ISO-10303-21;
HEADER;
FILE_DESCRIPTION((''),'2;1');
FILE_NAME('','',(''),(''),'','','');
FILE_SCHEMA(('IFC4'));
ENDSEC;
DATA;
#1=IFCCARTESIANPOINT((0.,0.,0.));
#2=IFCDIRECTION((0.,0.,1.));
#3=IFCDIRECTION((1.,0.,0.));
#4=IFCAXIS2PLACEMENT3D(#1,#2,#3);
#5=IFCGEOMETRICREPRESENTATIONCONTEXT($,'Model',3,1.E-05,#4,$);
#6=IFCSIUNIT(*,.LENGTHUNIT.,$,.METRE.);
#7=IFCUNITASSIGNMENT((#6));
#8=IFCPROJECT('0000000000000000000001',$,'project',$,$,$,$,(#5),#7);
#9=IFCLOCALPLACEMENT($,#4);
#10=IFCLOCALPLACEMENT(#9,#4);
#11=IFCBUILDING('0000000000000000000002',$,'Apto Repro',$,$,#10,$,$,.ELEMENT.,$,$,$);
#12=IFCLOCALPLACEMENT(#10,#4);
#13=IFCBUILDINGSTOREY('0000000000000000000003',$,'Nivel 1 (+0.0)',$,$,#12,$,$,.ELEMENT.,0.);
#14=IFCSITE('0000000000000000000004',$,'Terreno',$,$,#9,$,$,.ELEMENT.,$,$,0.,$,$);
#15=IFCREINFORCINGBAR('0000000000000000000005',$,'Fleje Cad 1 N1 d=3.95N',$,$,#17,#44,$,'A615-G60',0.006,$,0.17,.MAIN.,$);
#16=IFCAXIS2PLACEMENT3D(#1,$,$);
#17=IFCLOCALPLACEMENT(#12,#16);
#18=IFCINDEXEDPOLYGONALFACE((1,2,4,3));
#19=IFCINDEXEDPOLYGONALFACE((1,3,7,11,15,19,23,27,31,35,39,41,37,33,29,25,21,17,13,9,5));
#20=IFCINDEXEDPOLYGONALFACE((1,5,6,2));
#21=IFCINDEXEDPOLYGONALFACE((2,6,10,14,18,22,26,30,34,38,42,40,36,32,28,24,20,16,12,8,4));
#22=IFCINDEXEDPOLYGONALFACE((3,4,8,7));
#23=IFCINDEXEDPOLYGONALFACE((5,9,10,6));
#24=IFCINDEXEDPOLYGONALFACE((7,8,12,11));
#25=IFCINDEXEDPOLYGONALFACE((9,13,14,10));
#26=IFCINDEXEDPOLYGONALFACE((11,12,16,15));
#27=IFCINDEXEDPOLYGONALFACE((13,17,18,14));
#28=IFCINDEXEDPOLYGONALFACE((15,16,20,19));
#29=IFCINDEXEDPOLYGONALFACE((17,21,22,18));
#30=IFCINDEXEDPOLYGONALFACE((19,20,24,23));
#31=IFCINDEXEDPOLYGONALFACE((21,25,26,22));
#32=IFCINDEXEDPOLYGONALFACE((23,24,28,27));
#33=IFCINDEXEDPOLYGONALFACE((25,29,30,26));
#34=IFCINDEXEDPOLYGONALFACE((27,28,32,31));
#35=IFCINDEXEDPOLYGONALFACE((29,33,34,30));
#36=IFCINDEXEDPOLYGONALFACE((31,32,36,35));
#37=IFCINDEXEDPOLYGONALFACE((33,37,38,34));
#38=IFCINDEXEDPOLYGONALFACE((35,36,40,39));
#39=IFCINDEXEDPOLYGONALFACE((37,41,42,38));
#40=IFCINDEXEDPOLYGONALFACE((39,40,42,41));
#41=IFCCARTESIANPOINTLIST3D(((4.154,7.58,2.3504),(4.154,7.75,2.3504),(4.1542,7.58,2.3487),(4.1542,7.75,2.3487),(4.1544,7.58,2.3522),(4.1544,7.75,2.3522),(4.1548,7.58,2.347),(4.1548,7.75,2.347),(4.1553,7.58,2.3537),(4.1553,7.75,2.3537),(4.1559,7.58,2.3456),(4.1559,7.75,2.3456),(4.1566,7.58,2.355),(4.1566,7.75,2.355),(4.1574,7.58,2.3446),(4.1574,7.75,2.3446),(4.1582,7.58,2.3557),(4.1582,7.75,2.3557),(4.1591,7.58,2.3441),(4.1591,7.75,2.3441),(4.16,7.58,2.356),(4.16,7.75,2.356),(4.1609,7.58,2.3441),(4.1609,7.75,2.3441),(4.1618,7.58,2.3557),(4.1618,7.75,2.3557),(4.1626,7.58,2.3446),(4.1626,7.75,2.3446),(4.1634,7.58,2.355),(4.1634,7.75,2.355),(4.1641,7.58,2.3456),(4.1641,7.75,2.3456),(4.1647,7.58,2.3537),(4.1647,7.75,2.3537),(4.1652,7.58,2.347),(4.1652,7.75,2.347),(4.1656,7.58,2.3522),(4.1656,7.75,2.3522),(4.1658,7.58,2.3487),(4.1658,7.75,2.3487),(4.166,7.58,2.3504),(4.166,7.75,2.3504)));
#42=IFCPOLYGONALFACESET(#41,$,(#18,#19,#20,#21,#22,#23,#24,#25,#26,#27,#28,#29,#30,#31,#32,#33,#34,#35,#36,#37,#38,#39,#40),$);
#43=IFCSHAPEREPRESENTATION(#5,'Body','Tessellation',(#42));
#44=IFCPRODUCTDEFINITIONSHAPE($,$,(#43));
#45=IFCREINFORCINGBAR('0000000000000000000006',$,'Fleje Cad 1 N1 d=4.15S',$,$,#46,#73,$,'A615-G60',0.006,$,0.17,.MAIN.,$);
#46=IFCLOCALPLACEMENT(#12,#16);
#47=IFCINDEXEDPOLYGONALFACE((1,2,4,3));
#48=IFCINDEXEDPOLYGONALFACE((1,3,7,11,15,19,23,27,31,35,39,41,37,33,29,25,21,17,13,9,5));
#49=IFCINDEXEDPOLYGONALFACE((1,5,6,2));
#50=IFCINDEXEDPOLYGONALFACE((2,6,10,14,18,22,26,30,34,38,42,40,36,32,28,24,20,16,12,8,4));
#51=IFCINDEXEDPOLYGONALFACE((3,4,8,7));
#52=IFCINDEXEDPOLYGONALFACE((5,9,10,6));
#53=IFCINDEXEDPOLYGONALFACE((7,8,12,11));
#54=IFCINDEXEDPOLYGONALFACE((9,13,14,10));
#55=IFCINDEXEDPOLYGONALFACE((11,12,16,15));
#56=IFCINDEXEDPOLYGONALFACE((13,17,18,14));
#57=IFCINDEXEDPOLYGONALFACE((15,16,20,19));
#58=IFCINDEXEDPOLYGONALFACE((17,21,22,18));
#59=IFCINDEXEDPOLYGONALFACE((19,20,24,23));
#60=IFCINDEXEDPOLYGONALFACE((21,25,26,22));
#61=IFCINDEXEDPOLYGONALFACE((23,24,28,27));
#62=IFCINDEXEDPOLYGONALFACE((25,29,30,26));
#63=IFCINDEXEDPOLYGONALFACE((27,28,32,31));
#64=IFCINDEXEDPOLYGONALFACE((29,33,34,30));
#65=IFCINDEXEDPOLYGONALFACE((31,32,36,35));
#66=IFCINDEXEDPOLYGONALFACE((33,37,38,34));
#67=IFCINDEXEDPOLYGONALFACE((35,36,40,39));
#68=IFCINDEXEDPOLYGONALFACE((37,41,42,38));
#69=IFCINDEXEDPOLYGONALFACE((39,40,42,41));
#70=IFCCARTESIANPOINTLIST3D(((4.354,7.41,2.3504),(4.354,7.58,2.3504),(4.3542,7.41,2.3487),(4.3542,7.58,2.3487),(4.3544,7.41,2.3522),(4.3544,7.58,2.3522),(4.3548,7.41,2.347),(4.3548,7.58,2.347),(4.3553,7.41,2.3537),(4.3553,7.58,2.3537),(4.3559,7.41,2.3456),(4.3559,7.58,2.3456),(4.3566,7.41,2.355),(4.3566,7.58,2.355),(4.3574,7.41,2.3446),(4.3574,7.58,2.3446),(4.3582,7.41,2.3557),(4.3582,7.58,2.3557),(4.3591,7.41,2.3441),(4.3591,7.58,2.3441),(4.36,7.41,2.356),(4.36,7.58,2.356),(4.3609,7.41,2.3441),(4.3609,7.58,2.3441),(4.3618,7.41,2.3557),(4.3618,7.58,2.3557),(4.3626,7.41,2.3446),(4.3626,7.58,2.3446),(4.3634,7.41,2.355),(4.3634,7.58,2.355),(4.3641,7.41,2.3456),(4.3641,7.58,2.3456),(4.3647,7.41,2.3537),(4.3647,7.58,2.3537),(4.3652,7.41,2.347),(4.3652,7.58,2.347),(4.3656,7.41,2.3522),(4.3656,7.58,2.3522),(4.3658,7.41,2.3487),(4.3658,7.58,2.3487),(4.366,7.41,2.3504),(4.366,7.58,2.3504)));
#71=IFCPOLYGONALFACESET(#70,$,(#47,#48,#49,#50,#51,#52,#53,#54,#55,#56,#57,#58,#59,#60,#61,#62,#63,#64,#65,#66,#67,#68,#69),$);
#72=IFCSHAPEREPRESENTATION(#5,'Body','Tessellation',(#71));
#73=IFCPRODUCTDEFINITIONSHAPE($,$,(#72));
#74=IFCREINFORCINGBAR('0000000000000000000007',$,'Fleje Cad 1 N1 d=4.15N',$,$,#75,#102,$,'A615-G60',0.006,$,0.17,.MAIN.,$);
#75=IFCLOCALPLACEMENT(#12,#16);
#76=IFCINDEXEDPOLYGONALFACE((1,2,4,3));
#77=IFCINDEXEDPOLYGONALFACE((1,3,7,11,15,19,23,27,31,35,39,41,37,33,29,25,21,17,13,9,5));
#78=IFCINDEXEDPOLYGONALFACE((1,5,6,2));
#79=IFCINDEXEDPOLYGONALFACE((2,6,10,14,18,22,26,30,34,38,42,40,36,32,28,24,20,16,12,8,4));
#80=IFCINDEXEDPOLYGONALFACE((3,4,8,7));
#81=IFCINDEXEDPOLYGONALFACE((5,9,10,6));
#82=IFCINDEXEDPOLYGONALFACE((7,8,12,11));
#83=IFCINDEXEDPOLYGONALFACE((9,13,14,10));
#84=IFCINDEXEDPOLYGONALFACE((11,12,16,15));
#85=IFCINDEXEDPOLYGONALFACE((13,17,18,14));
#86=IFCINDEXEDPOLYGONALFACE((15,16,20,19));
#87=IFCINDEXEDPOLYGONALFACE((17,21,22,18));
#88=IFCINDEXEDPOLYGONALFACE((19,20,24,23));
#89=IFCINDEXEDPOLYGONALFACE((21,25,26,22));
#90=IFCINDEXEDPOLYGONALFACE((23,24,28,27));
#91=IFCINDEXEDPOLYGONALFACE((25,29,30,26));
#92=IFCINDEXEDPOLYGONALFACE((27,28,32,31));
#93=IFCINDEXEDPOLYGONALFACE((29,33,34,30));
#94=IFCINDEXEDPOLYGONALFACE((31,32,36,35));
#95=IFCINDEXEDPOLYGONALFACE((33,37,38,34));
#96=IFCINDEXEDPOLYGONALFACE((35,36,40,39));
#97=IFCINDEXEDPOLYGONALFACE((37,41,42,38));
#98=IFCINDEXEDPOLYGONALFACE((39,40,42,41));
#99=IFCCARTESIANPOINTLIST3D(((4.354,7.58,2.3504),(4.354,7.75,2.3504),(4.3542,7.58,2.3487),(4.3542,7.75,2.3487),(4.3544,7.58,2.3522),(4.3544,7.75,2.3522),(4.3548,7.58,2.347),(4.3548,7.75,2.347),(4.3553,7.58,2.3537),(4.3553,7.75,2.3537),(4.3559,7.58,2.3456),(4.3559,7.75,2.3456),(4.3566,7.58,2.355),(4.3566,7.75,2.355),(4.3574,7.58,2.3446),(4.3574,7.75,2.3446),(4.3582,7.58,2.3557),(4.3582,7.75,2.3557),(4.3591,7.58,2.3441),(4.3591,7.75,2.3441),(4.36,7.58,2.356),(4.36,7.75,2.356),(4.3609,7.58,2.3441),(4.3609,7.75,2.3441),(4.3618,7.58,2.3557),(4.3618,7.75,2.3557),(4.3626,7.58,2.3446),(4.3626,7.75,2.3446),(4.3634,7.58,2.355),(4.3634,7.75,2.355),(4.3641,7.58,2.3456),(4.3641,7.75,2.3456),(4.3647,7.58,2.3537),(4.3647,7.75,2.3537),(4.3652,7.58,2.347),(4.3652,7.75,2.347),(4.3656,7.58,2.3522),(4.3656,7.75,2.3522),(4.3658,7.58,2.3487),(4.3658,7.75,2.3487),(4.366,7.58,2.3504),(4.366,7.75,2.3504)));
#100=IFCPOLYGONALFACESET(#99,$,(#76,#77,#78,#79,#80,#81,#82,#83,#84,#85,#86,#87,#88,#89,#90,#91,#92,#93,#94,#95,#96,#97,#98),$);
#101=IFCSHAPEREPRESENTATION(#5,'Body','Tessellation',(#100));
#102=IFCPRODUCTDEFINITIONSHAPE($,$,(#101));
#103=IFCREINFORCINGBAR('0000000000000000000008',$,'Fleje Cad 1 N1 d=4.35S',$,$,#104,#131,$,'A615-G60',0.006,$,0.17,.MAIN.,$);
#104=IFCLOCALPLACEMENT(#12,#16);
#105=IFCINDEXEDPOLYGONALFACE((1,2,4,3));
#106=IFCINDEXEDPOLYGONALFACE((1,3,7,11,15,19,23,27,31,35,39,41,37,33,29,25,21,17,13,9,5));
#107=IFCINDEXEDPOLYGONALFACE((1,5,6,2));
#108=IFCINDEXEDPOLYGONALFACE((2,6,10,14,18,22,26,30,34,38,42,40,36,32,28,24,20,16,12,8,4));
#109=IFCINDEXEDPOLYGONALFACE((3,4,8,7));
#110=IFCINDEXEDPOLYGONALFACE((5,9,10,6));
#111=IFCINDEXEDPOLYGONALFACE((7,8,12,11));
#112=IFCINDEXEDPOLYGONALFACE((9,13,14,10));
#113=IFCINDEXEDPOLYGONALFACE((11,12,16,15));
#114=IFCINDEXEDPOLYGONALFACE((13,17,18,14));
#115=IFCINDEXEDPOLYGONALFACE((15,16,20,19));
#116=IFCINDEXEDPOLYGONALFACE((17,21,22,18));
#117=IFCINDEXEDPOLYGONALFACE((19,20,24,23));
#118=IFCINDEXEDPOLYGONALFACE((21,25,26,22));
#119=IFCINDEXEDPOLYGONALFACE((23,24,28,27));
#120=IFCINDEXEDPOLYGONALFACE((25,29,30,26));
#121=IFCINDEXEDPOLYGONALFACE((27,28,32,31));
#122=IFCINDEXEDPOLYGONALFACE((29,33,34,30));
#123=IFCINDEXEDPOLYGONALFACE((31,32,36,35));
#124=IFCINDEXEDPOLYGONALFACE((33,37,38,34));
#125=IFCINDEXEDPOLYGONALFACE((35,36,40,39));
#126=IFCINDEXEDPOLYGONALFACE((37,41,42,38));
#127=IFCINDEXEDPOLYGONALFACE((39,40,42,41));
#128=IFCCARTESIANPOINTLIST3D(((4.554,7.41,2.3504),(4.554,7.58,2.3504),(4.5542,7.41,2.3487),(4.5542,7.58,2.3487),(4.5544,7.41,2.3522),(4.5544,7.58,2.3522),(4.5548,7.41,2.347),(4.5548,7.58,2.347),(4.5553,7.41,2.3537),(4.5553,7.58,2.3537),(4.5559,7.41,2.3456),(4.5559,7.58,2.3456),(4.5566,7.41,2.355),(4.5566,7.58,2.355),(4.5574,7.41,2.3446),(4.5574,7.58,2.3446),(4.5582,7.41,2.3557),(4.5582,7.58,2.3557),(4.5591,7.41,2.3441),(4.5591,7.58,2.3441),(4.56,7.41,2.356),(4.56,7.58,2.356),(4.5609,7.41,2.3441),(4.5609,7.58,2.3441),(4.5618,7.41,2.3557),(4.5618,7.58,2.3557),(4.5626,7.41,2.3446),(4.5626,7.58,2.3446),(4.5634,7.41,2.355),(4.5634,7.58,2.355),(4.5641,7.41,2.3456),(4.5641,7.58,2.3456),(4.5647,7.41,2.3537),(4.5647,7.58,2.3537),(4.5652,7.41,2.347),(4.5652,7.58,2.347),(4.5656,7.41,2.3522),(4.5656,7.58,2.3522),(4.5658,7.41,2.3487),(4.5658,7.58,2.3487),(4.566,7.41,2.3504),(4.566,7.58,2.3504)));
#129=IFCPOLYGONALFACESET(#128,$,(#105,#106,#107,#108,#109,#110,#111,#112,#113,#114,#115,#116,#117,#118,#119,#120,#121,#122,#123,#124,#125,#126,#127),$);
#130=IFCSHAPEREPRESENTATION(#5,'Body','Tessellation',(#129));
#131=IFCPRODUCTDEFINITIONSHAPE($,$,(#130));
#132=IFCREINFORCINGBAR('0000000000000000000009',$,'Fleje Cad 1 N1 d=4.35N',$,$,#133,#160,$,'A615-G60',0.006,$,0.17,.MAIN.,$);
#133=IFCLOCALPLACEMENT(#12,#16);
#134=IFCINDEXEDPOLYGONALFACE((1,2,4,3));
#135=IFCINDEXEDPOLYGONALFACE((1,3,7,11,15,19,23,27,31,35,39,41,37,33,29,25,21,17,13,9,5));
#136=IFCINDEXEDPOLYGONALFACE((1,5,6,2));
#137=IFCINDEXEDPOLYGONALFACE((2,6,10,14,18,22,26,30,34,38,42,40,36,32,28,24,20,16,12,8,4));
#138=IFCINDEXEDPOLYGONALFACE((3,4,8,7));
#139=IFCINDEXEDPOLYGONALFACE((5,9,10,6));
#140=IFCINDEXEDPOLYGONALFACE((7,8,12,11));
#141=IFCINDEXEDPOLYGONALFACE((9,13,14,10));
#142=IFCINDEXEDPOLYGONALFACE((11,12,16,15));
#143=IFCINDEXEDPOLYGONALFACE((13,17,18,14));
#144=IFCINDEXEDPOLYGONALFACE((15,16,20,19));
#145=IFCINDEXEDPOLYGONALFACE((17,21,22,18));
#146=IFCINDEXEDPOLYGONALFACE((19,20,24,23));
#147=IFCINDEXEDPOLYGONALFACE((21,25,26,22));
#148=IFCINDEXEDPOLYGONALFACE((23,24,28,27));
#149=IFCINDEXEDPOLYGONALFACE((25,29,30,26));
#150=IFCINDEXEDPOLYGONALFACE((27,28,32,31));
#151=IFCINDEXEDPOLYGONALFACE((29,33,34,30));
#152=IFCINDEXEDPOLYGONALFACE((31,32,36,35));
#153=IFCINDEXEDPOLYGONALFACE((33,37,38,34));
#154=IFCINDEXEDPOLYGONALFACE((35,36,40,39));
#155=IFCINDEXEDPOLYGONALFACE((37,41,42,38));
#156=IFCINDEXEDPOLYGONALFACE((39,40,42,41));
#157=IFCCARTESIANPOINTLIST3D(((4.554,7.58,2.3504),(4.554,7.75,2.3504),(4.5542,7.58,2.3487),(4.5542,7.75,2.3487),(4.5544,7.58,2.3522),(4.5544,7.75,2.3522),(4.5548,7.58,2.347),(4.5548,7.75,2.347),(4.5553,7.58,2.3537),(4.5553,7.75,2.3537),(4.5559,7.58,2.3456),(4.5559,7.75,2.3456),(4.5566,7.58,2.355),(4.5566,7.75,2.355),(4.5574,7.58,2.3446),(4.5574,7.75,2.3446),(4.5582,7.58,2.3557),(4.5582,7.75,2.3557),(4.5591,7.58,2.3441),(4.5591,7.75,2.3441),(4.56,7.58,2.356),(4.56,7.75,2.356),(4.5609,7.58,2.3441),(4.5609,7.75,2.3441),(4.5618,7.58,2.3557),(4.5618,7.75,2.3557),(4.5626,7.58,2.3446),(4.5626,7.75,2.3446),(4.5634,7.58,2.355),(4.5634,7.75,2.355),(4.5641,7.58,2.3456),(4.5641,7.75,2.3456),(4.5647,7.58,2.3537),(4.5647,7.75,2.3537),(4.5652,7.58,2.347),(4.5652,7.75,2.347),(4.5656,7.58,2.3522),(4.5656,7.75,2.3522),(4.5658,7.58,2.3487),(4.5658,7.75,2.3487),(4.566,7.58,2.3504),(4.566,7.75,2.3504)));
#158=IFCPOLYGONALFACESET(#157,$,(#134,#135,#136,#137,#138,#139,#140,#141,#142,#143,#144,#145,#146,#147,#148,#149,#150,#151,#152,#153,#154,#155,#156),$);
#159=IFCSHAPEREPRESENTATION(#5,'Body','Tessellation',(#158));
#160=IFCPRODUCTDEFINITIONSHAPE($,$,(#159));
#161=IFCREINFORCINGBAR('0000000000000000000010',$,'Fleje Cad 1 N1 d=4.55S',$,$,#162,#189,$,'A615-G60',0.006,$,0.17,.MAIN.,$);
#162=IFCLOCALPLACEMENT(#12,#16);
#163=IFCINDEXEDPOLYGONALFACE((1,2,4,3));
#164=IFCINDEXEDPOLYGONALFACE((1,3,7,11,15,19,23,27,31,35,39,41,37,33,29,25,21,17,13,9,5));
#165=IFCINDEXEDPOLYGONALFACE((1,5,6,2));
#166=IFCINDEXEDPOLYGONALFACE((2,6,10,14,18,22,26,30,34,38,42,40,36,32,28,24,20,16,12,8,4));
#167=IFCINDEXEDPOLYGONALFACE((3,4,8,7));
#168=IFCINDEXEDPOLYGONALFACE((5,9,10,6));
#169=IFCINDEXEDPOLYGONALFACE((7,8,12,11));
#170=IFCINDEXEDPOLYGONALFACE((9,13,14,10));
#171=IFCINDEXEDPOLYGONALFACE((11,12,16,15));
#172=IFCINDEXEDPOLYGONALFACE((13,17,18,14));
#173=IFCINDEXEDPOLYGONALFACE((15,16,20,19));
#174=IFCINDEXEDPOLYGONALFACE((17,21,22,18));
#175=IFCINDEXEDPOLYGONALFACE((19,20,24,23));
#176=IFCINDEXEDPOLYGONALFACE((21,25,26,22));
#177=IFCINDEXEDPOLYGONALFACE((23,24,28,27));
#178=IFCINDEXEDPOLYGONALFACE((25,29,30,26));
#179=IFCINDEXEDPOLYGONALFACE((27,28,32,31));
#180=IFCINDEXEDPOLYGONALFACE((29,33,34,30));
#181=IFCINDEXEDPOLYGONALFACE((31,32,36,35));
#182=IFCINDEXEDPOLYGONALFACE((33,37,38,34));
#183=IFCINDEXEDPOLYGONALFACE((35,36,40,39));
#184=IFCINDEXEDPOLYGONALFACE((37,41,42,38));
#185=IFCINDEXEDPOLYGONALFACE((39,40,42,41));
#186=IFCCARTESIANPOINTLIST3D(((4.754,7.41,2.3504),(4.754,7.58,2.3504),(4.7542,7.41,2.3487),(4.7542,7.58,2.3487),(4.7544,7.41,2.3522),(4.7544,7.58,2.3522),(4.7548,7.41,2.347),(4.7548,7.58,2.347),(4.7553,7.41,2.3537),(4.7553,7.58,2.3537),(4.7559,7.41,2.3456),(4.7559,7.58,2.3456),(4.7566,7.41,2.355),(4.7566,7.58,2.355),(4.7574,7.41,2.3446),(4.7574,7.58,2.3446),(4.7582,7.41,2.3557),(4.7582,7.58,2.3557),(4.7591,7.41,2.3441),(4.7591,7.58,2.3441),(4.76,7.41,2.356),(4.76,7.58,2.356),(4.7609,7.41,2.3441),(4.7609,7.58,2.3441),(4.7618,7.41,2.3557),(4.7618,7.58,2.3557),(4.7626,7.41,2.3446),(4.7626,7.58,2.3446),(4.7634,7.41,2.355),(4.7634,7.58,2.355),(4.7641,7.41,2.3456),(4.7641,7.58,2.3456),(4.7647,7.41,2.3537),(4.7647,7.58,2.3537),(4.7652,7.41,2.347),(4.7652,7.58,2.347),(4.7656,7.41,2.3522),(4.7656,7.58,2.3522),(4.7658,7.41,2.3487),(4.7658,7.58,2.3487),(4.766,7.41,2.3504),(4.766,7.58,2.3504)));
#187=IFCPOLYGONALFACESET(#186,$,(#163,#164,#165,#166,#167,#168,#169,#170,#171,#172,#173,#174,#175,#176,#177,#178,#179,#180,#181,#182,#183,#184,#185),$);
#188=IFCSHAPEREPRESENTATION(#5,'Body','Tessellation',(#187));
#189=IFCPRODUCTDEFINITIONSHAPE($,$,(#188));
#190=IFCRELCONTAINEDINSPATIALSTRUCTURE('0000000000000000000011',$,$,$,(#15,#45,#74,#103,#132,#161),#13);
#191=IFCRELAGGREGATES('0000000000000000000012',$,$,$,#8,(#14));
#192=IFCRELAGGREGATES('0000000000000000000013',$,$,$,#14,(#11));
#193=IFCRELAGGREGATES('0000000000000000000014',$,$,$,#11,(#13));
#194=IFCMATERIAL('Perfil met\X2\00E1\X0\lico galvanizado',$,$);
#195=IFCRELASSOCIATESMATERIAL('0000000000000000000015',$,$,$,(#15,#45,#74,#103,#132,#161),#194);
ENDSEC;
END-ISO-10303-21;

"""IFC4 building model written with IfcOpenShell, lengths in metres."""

from ifc_helpers import new_model, si_unit, frame, origin_with_axes, origin_2d_with_axis, place, context, project, spatial, circle, extrude, material, element, save


model = new_model("IFC4")

# Units and contexts
model_context = context("Model", 3, precision=1e-05, world=origin_with_axes())
ifc_project = project(units=[si_unit("LENGTHUNIT", "METRE")], contexts=[model_context])

# Site, building, storey
site_placement = place(None, origin_with_axes())
site = spatial("IfcSite", under=ifc_project, at=site_placement, Name="Terreno", CompositionType="ELEMENT", RefElevation=0.0)
building_placement = place(site_placement, origin_with_axes())
building = spatial("IfcBuilding", under=site, at=building_placement, Name="Apto Repro", CompositionType="ELEMENT")
storey_placement = place(building_placement, origin_with_axes())
storey = spatial("IfcBuildingStorey", under=building, at=storey_placement, Name="Nivel 1 (+0.0)", CompositionType="ELEMENT", Elevation=0.0)

# Reinforcing bars
ifc_material = material(Name="Perfil metálico galvanizado")
reinforcing_bar_1_placement = place(storey_placement, origin_with_axes())
element("IfcReinforcingBar", 1, at=reinforcing_bar_1_placement, inside=storey, material=ifc_material, Name="Fleje Cad 1 N1 d=3.95N", SteelGrade="A615-G60", BarLength=0.17, NominalDiameter=0.006, PredefinedType="MAIN", context=model_context, shape_type="SweptSolid", body=[
    extrude(circle(Radius=0.006, at=origin_2d_with_axis()), frame((4.16, 7.58, 2.35), z_axis=(0.0, 1.0, 0.0), x_axis=(0.0, 0.0, 1.0)), (0.0, 0.0, 1.0), 0.17),
])
reinforcing_bar_2_placement = place(storey_placement, origin_with_axes())
element("IfcReinforcingBar", 2, at=reinforcing_bar_2_placement, inside=storey, material=ifc_material, Name="Fleje Cad 1 N1 d=4.15S", SteelGrade="A615-G60", BarLength=0.17, NominalDiameter=0.006, PredefinedType="MAIN", context=model_context, shape_type="SweptSolid", body=[
    extrude(circle(Radius=0.006, at=origin_2d_with_axis()), frame((4.36, 7.41, 2.35), z_axis=(0.0, 1.0, 0.0), x_axis=(0.0, 0.0, 1.0)), (0.0, 0.0, 1.0), 0.17),
])
reinforcing_bar_3_placement = place(storey_placement, origin_with_axes())
element("IfcReinforcingBar", 3, at=reinforcing_bar_3_placement, inside=storey, material=ifc_material, Name="Fleje Cad 1 N1 d=4.15N", SteelGrade="A615-G60", BarLength=0.17, NominalDiameter=0.006, PredefinedType="MAIN", context=model_context, shape_type="SweptSolid", body=[
    extrude(circle(Radius=0.006, at=origin_2d_with_axis()), frame((4.36, 7.58, 2.35), z_axis=(0.0, 1.0, 0.0), x_axis=(0.0, 0.0, 1.0)), (0.0, 0.0, 1.0), 0.17),
])
reinforcing_bar_4_placement = place(storey_placement, origin_with_axes())
element("IfcReinforcingBar", 4, at=reinforcing_bar_4_placement, inside=storey, material=ifc_material, Name="Fleje Cad 1 N1 d=4.35S", SteelGrade="A615-G60", BarLength=0.17, NominalDiameter=0.006, PredefinedType="MAIN", context=model_context, shape_type="SweptSolid", body=[
    extrude(circle(Radius=0.006, at=origin_2d_with_axis()), frame((4.56, 7.41, 2.35), z_axis=(0.0, 1.0, 0.0), x_axis=(0.0, 0.0, 1.0)), (0.0, 0.0, 1.0), 0.17),
])
reinforcing_bar_5_placement = place(storey_placement, origin_with_axes())
element("IfcReinforcingBar", 5, at=reinforcing_bar_5_placement, inside=storey, material=ifc_material, Name="Fleje Cad 1 N1 d=4.35N", SteelGrade="A615-G60", BarLength=0.17, NominalDiameter=0.006, PredefinedType="MAIN", context=model_context, shape_type="SweptSolid", body=[
    extrude(circle(Radius=0.006, at=origin_2d_with_axis()), frame((4.56, 7.58, 2.35), z_axis=(0.0, 1.0, 0.0), x_axis=(0.0, 0.0, 1.0)), (0.0, 0.0, 1.0), 0.17),
])
reinforcing_bar_6_placement = place(storey_placement, origin_with_axes())
element("IfcReinforcingBar", 6, at=reinforcing_bar_6_placement, inside=storey, material=ifc_material, Name="Fleje Cad 1 N1 d=4.55S", SteelGrade="A615-G60", BarLength=0.17, NominalDiameter=0.006, PredefinedType="MAIN", context=model_context, shape_type="SweptSolid", body=[
    extrude(circle(Radius=0.006, at=origin_2d_with_axis()), frame((4.76, 7.41, 2.35), z_axis=(0.0, 1.0, 0.0), x_axis=(0.0, 0.0, 1.0)), (0.0, 0.0, 1.0), 0.17),
])

save(model, "model.ifc")
